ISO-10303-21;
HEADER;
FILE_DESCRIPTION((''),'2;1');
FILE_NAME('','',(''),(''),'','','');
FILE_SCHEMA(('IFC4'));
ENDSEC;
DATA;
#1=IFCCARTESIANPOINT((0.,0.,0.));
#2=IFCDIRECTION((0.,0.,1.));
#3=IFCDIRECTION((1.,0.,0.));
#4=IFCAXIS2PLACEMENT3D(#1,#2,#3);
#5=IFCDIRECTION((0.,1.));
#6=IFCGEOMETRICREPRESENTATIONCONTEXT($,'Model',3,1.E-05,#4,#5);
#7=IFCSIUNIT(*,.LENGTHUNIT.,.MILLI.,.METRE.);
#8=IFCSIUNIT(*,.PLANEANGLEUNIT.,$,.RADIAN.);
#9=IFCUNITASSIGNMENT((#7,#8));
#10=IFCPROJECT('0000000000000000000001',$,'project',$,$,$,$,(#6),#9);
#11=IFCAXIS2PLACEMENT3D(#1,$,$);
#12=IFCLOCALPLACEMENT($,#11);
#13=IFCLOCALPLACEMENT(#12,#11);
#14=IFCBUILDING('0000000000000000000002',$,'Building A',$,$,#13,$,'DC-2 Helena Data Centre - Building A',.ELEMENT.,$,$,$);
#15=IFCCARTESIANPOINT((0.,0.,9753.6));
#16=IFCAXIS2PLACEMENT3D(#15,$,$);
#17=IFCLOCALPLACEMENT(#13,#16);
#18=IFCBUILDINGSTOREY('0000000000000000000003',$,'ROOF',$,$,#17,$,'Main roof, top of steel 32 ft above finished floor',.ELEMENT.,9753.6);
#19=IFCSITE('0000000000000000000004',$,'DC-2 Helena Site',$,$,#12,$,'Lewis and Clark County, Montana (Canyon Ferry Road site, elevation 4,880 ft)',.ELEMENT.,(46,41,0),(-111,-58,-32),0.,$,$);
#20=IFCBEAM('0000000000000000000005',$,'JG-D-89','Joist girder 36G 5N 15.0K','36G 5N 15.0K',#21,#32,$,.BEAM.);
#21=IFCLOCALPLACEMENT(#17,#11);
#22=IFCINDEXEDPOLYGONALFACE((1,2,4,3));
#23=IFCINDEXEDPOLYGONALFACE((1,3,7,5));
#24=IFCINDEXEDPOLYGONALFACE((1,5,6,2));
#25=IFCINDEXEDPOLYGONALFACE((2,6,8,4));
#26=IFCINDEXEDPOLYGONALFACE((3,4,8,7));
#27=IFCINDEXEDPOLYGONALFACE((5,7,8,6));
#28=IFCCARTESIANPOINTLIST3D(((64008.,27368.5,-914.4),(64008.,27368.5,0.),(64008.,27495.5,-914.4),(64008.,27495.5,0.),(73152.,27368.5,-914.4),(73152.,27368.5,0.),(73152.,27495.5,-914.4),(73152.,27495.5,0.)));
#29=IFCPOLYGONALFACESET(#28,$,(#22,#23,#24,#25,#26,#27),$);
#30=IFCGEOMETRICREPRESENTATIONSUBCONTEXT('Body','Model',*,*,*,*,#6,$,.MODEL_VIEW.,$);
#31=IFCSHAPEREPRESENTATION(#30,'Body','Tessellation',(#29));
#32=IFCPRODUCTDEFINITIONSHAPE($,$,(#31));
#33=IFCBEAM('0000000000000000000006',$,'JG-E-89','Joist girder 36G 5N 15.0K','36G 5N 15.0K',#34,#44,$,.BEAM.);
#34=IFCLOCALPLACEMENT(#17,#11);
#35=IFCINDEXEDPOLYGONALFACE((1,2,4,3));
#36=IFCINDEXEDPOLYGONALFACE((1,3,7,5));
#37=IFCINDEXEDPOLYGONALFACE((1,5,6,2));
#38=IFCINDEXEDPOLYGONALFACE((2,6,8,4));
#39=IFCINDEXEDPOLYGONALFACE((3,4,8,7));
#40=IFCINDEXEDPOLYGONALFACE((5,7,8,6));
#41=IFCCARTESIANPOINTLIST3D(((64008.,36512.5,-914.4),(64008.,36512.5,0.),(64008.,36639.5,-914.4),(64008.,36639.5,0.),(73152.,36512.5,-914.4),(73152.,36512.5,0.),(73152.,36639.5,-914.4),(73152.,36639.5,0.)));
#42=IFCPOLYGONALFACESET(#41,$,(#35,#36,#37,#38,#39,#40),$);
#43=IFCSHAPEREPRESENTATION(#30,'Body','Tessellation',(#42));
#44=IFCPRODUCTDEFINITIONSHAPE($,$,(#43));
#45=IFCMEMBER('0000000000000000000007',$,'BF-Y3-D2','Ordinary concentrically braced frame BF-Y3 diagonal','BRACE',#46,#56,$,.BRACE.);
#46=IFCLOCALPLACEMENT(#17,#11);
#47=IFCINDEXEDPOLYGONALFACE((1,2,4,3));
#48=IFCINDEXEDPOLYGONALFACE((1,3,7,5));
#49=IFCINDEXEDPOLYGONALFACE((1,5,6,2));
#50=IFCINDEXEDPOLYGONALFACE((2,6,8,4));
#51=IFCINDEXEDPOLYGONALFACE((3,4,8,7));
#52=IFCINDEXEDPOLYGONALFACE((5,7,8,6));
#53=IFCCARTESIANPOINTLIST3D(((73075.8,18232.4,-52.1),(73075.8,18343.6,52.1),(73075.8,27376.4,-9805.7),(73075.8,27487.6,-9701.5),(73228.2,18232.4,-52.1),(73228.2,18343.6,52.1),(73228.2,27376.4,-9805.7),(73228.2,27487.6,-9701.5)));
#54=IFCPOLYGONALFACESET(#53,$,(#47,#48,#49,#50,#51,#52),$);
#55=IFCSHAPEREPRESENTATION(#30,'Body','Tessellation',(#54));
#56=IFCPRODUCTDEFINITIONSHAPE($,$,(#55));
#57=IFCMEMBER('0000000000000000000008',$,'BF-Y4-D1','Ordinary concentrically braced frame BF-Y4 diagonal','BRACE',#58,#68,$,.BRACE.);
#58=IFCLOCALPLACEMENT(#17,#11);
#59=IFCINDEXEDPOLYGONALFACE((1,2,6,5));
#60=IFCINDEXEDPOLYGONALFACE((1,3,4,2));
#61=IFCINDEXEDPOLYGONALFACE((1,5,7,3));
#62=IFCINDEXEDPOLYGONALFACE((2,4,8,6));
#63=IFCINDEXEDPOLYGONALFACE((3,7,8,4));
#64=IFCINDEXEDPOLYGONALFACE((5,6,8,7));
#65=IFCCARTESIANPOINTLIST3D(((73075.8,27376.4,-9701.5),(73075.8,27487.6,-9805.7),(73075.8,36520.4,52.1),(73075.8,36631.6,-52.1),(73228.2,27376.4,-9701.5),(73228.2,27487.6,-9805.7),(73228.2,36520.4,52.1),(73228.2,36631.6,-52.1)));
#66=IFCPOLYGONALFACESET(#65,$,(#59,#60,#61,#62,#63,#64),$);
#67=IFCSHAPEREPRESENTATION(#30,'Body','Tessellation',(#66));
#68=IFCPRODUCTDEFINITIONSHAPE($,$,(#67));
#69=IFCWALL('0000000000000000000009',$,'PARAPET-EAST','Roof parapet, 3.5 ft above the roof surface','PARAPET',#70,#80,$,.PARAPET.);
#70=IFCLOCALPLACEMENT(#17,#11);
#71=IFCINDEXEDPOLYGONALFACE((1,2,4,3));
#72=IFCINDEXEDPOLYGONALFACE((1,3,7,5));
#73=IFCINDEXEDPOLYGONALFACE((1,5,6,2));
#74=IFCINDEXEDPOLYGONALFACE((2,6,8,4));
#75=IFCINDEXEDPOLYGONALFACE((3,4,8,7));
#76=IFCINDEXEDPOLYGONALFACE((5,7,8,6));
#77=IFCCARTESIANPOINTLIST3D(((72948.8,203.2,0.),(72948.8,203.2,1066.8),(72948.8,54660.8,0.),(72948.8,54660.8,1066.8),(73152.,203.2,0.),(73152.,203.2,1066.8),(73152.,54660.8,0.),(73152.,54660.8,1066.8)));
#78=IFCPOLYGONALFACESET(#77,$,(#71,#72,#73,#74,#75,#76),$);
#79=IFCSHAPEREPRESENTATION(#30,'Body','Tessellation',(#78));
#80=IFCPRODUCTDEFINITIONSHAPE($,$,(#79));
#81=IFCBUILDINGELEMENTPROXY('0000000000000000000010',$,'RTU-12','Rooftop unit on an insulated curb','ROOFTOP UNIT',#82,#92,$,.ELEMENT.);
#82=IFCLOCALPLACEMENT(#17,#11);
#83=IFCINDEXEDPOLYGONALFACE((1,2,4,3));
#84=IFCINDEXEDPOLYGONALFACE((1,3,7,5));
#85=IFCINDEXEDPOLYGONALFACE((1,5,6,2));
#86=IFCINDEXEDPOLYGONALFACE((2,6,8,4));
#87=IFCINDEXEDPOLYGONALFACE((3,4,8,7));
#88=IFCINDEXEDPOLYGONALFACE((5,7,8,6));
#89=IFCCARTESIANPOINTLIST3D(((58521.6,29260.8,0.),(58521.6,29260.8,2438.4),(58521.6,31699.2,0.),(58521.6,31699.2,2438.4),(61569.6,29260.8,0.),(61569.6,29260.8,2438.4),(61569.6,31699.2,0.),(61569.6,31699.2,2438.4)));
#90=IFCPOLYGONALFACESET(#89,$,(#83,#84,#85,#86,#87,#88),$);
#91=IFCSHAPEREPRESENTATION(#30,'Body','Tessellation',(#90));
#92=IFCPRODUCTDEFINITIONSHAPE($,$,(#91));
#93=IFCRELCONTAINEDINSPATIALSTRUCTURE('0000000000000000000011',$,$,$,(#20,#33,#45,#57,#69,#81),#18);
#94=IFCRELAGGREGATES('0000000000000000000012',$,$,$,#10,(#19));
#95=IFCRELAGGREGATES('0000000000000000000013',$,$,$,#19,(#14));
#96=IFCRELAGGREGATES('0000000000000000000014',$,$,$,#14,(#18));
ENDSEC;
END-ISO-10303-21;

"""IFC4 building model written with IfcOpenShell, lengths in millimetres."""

from ifc_helpers import new_model, si_unit, direction, frame, origin, origin_with_axes, origin_2d, place, context, subcontext, project, spatial, rectangle, extrude, element, save


model = new_model("IFC4")

# Units and contexts
model_context = context("Model", 3, precision=1e-05, world=origin_with_axes(), true_north=direction((0.0, 1.0)))
body_context = subcontext(model_context, "Body", "Model", "MODEL_VIEW")
ifc_project = project(units=[si_unit("LENGTHUNIT", "METRE", prefix="MILLI"), si_unit("PLANEANGLEUNIT", "RADIAN")], contexts=[model_context])

# Site, building, storey
site_placement = place(None, origin())
site = spatial("IfcSite", under=ifc_project, at=site_placement, Name="DC-2 Helena Site", LongName="Lewis and Clark County, Montana (Canyon Ferry Road site, elevation 4,880 ft)", CompositionType="ELEMENT", RefLatitude=(46, 41, 0), RefLongitude=(-111, -58, -32), RefElevation=0.0)
building_placement = place(site_placement, origin())
building = spatial("IfcBuilding", under=site, at=building_placement, Name="Building A", LongName="DC-2 Helena Data Centre - Building A", CompositionType="ELEMENT")
storey_placement = place(building_placement, frame((0.0, 0.0, 9753.6)))
storey = spatial("IfcBuildingStorey", under=building, at=storey_placement, Name="ROOF", LongName="Main roof, top of steel 32 ft above finished floor", CompositionType="ELEMENT", Elevation=9753.6)

# Shared definitions
placement_1 = place(storey_placement, frame((73152.0, 27432.0, -9753.6)))

# Beams
placement_2 = place(storey_placement, frame((64008.0, 27432.0, 0.0)))
placement_3 = place(storey_placement, frame((64008.0, 36576.0, 0.0)))
element("IfcBeam", 1, at=placement_2, inside=storey, Name="JG-D-89", Description="Joist girder 36G 5N 15.0K", ObjectType="36G 5N 15.0K", PredefinedType="BEAM", context=body_context, shape_type="SweptSolid", body=[
    extrude(rectangle(XDim=127.0, YDim=914.4, at=origin_2d()), frame((0.0, 0.0, -457.2), z_axis=(1.0, 0.0, 0.0), x_axis=(0.0, 1.0, 0.0)), (0.0, 0.0, 1.0), 9144.0),
])
element("IfcBeam", 2, at=placement_3, inside=storey, Name="JG-E-89", Description="Joist girder 36G 5N 15.0K", ObjectType="36G 5N 15.0K", PredefinedType="BEAM", context=body_context, shape_type="SweptSolid", body=[
    extrude(rectangle(XDim=127.0, YDim=914.4, at=origin_2d()), frame((0.0, 0.0, -457.2), z_axis=(1.0, 0.0, 0.0), x_axis=(0.0, 1.0, 0.0)), (0.0, 0.0, 1.0), 9144.0),
])

# Members
element("IfcMember", 3, at=placement_1, inside=storey, Name="BF-Y3-D2", Description="Ordinary concentrically braced frame BF-Y3 diagonal", ObjectType="BRACE", PredefinedType="BRACE", context=body_context, shape_type="SweptSolid", body=[
    extrude(rectangle(XDim=152.4, YDim=152.4, at=origin_2d()), frame((0.0, 0.0, 0.0), z_axis=(0.0, -0.683941, 0.729537), x_axis=(1.0, 0.0, 0.0)), (0.0, 0.0, 1.0), 13369.6),
])
element("IfcMember", 4, at=placement_1, inside=storey, Name="BF-Y4-D1", Description="Ordinary concentrically braced frame BF-Y4 diagonal", ObjectType="BRACE", PredefinedType="BRACE", context=body_context, shape_type="SweptSolid", body=[
    extrude(rectangle(XDim=152.4, YDim=152.4, at=origin_2d()), frame((0.0, 0.0, 0.0), z_axis=(0.0, 0.683941, 0.729537), x_axis=(1.0, 0.0, 0.0)), (0.0, 0.0, 1.0), 13369.6),
])

# Wall
wall_placement = place(storey_placement, frame((73050.4, 27432.0, 0.0)))
element("IfcWall", 5, at=wall_placement, inside=storey, Name="PARAPET-EAST", Description="Roof parapet, 3.5 ft above the roof surface", ObjectType="PARAPET", PredefinedType="PARAPET", context=body_context, shape_type="SweptSolid", body=[
    extrude(rectangle(XDim=203.2, YDim=54457.6, at=origin_2d()), origin(), (0.0, 0.0, 1.0), 1066.8),
])

# Building element proxy
proxy_placement = place(storey_placement, frame((60045.6, 30480.0, 0.0)))
element("IfcBuildingElementProxy", 6, at=proxy_placement, inside=storey, Name="RTU-12", Description="Rooftop unit on an insulated curb", ObjectType="ROOFTOP UNIT", PredefinedType="ELEMENT", context=body_context, shape_type="SweptSolid", body=[
    extrude(rectangle(XDim=3048.0, YDim=2438.4, at=origin_2d()), origin(), (0.0, 0.0, 1.0), 2438.4),
])

save(model, "model.ifc")
